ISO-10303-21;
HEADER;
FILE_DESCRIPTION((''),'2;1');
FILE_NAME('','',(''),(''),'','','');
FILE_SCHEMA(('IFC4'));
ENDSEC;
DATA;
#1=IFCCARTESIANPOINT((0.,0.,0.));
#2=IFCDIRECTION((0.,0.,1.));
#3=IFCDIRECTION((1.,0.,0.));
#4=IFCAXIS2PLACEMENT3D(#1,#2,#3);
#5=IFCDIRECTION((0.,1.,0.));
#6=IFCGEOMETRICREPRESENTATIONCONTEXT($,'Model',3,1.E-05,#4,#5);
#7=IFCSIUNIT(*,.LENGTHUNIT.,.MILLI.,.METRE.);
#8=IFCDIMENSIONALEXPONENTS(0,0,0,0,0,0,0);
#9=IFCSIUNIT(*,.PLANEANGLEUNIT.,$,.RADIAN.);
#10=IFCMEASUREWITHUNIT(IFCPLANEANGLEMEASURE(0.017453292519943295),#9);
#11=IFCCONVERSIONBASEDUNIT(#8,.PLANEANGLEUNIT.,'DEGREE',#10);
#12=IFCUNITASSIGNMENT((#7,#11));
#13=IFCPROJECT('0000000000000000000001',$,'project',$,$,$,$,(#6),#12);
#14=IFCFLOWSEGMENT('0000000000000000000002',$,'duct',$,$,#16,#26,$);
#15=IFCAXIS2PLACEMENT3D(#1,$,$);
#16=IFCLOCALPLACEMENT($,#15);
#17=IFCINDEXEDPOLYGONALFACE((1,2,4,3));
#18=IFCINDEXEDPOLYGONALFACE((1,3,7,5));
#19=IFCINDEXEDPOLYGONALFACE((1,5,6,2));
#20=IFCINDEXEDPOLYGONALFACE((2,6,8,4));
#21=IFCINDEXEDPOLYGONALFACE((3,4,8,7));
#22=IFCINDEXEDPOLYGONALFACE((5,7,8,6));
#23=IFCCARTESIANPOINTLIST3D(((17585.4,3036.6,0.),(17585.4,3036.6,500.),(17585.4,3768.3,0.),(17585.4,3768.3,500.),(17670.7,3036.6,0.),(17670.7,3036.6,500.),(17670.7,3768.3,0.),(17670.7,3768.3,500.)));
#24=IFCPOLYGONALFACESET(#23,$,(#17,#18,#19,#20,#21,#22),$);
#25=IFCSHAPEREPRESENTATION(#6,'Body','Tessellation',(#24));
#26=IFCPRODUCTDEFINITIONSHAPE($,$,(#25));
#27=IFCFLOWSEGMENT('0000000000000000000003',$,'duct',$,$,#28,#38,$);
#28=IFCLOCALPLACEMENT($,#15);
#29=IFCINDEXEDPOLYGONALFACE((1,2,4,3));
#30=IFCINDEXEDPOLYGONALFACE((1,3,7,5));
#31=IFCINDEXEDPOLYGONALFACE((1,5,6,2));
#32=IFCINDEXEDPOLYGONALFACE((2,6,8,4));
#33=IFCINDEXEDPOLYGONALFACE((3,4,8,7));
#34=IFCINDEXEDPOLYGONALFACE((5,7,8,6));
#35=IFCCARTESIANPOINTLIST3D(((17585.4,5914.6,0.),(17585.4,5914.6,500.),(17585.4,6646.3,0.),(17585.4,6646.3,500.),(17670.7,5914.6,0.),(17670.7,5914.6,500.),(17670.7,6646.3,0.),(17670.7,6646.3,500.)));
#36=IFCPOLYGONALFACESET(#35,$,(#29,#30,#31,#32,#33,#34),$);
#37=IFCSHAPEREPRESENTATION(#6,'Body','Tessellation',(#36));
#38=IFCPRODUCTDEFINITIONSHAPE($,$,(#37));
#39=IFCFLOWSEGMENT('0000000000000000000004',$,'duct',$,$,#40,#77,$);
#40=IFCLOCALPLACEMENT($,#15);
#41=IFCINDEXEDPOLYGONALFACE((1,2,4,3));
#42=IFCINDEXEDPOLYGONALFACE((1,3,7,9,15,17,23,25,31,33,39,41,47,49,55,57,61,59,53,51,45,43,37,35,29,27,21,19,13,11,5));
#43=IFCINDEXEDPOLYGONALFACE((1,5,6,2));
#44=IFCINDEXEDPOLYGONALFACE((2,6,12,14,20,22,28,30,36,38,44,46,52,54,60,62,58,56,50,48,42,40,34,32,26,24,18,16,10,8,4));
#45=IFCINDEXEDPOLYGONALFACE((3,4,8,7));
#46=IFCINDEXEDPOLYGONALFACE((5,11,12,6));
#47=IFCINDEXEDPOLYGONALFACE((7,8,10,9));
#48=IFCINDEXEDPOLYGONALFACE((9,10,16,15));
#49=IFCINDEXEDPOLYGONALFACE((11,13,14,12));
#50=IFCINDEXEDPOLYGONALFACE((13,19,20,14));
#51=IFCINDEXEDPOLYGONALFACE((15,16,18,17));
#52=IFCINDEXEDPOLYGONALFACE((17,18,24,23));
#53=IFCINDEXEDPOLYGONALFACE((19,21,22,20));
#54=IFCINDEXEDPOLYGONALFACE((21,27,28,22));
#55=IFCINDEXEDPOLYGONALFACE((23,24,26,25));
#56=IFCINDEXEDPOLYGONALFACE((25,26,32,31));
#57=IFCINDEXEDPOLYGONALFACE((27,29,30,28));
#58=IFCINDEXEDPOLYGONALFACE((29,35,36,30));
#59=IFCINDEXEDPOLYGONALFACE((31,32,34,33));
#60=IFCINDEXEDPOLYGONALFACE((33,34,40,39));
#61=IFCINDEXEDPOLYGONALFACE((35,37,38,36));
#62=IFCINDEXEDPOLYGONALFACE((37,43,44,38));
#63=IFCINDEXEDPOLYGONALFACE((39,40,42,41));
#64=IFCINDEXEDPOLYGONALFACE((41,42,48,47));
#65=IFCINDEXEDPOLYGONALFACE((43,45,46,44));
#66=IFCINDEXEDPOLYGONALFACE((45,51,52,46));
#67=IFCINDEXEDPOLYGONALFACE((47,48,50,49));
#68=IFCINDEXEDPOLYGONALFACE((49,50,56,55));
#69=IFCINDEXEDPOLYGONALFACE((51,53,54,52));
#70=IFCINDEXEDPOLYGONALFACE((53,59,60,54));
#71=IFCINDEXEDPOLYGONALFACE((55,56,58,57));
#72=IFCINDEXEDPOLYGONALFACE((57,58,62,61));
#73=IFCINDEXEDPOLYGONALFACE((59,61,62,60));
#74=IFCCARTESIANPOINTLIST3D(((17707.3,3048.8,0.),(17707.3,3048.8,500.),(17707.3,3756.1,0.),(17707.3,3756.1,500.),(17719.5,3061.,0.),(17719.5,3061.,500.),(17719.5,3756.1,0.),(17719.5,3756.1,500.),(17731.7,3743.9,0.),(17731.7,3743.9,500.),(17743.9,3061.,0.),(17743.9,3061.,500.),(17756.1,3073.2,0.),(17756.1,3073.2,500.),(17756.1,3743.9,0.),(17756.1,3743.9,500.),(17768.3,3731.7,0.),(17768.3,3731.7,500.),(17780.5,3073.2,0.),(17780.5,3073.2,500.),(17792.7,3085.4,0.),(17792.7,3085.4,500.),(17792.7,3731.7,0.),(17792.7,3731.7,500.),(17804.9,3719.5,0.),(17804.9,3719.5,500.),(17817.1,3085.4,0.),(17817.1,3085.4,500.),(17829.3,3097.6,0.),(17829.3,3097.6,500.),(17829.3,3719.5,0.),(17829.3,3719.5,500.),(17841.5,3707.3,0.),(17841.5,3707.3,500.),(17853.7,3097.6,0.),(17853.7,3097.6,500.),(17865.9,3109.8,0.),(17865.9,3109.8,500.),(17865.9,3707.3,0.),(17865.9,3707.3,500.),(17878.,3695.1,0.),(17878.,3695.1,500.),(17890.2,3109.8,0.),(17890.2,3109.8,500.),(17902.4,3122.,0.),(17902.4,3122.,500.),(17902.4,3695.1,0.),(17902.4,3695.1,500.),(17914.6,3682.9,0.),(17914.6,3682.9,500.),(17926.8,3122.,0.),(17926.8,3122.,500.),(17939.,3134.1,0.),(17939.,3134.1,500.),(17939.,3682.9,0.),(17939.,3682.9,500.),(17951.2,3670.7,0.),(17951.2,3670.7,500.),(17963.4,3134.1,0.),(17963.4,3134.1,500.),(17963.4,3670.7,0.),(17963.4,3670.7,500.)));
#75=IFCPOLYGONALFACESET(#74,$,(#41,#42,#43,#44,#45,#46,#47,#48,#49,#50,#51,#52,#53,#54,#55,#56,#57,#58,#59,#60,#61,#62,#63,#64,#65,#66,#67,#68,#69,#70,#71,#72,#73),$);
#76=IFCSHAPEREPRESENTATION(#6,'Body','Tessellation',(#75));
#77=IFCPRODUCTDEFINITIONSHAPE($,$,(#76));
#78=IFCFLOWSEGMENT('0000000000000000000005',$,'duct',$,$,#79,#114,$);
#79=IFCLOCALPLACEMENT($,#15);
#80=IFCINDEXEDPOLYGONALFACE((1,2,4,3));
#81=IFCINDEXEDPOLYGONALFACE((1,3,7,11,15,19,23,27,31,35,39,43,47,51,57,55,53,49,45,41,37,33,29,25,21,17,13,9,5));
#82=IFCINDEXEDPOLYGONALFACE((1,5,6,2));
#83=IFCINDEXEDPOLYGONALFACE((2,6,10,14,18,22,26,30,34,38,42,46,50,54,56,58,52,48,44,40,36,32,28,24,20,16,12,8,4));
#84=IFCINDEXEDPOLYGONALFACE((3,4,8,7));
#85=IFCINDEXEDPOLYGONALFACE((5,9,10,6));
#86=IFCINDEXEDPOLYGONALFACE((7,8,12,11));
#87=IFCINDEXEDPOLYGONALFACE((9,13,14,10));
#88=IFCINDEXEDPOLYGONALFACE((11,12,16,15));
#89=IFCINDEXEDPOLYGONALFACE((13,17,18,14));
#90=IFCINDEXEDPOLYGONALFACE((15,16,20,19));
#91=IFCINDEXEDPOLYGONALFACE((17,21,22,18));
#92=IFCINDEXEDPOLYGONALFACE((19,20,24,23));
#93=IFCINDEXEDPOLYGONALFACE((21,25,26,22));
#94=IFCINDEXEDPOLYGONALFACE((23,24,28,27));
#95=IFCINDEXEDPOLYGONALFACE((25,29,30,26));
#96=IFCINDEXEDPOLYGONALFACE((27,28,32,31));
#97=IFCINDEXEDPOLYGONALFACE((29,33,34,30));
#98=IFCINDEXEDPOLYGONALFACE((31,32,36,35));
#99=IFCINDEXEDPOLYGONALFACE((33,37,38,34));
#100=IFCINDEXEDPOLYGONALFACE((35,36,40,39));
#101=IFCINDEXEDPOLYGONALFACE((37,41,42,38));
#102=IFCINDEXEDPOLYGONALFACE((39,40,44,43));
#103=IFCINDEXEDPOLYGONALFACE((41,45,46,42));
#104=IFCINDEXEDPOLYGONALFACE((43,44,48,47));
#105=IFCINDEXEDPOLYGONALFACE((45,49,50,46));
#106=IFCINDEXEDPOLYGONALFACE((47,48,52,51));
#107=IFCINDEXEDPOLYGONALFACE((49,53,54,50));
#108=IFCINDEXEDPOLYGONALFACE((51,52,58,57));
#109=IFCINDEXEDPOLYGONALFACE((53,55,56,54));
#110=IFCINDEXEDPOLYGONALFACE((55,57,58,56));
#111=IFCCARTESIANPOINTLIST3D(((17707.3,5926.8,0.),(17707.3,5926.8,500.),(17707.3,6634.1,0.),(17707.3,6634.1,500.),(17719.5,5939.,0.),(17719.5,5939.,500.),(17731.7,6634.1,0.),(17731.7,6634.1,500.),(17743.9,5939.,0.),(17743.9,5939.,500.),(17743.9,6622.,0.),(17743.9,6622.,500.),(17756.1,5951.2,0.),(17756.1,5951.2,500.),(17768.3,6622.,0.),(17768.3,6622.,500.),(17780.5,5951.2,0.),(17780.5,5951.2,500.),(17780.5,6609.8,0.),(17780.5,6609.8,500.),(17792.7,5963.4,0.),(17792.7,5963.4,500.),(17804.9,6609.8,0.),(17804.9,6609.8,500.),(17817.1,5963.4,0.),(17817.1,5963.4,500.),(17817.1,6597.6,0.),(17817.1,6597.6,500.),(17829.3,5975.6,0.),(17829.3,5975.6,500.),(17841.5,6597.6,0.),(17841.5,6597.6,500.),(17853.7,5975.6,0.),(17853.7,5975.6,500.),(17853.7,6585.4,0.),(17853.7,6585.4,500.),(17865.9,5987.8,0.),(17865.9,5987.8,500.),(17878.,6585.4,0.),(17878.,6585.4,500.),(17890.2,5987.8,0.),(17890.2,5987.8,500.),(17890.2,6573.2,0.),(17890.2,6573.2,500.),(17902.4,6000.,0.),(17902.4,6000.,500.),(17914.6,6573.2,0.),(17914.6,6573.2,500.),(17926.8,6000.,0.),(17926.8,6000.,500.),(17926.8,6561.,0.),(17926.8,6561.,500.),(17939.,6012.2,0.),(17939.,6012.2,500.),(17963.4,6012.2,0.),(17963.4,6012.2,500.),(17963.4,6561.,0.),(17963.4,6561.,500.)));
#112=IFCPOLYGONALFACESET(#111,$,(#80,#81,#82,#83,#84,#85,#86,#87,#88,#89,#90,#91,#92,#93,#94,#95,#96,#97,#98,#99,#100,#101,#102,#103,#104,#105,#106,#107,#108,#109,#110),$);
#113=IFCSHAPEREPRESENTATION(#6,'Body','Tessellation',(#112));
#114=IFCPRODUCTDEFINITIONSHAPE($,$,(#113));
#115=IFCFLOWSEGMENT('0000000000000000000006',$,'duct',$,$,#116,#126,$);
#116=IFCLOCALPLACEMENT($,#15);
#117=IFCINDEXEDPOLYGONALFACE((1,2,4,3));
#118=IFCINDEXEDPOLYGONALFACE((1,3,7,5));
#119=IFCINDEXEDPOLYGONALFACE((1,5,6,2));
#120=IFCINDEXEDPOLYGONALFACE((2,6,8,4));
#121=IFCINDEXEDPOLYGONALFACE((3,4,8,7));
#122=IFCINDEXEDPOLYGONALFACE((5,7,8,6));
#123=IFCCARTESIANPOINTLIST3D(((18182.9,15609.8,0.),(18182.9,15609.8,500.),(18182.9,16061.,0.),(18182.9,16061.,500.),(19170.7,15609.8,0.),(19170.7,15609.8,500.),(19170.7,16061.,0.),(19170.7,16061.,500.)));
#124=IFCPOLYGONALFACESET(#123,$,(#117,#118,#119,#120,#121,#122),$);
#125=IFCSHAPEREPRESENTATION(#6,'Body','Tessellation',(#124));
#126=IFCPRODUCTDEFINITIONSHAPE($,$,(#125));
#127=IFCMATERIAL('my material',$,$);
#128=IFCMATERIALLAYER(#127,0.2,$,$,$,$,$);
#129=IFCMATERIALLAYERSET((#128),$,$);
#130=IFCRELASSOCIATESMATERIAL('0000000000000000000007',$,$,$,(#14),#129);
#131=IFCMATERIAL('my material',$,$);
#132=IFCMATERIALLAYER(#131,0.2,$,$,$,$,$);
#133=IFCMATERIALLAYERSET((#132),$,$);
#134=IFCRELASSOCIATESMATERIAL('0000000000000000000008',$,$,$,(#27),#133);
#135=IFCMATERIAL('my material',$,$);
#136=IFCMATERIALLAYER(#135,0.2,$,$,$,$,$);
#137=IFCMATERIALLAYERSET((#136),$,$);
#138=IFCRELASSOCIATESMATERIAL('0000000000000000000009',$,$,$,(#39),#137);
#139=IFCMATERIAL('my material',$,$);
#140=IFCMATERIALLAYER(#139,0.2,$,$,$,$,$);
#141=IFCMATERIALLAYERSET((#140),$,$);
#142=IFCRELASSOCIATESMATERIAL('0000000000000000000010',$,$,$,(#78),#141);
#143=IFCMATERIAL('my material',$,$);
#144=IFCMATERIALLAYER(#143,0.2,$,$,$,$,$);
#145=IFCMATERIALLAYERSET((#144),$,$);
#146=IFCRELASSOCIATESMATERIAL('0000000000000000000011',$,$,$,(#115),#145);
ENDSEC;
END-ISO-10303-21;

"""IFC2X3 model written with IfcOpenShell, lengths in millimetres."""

from ifc_helpers import new_model, entity, si_unit, converted_unit, direction, origin_with_axes, place, context, project, polyline, outline, extrude, material, layer, layer_set, layer_usage, element, save


model = new_model("IFC2X3")

# Units and contexts
model_context = context("Model", 3, precision=1e-05, world=origin_with_axes(), true_north=direction((0.0, 1.0, 0.0)))
ifc_project = project(units=[si_unit("LENGTHUNIT", "METRE", prefix="MILLI"), converted_unit("PLANEANGLEUNIT", "DEGREE", entity("IfcPlaneAngleMeasure", 0.017453292519943295), si_unit("PLANEANGLEUNIT", "RADIAN"), dimensions=[0, 0, 0, 0, 0, 0, 0])], contexts=[model_context])

# Flow segments
ifc_material_1 = material(Name="my material")
ifc_layer_1 = layer(ifc_material_1, 0.2)
ifc_layer_set_1 = layer_set([ifc_layer_1])
ifc_layer_usage_1 = layer_usage(ifc_layer_set_1, "AXIS2", "POSITIVE", -0.1)
flow_segment_1_placement = place(None, origin_with_axes())
element("IfcFlowSegment", 1, at=flow_segment_1_placement, material=ifc_layer_usage_1, Name="duct", context=model_context, shape_type="SweptSolid", body=[
    extrude(outline(polyline([(17585.4, 3036.6), (17670.7, 3036.6), (17670.7, 3768.3), (17585.4, 3768.3), (17585.4, 3036.6)])), origin_with_axes(), (0.0, 0.0, 1.0), 500.0),
])
ifc_material_2 = material(Name="my material")
ifc_layer_2 = layer(ifc_material_2, 0.2)
ifc_layer_set_2 = layer_set([ifc_layer_2])
ifc_layer_usage_2 = layer_usage(ifc_layer_set_2, "AXIS2", "POSITIVE", -0.1)
flow_segment_2_placement = place(None, origin_with_axes())
element("IfcFlowSegment", 2, at=flow_segment_2_placement, material=ifc_layer_usage_2, Name="duct", context=model_context, shape_type="SweptSolid", body=[
    extrude(outline(polyline([(17585.4, 5914.6), (17670.7, 5914.6), (17670.7, 6646.3), (17585.4, 6646.3), (17585.4, 5914.6)])), origin_with_axes(), (0.0, 0.0, 1.0), 500.0),
])
ifc_material_3 = material(Name="my material")
ifc_layer_3 = layer(ifc_material_3, 0.2)
ifc_layer_set_3 = layer_set([ifc_layer_3])
ifc_layer_usage_3 = layer_usage(ifc_layer_set_3, "AXIS2", "POSITIVE", -0.1)
flow_segment_3_placement = place(None, origin_with_axes())
element("IfcFlowSegment", 3, at=flow_segment_3_placement, material=ifc_layer_usage_3, Name="duct", context=model_context, shape_type="SweptSolid", body=[
    extrude(outline(polyline([(17707.3, 3048.8), (17719.5, 3061.0), (17743.9, 3061.0), (17756.1, 3073.2), (17780.5, 3073.2), (17792.7, 3085.4), (17817.1, 3085.4), (17829.3, 3097.6), (17853.7, 3097.6), (17865.9, 3109.8), (17890.2, 3109.8), (17902.4, 3122.0), (17926.8, 3122.0), (17939.0, 3134.1), (17963.4, 3134.1), (17963.4, 3670.7), (17951.2, 3670.7), (17939.0, 3682.9), (17914.6, 3682.9), (17902.4, 3695.1), (17878.0, 3695.1), (17865.9, 3707.3), (17841.5, 3707.3), (17829.3, 3719.5), (17804.9, 3719.5), (17792.7, 3731.7), (17768.3, 3731.7), (17756.1, 3743.9), (17731.7, 3743.9), (17719.5, 3756.1), (17707.3, 3756.1), (17707.3, 3048.8)])), origin_with_axes(), (0.0, 0.0, 1.0), 500.0),
])
ifc_material_4 = material(Name="my material")
ifc_layer_4 = layer(ifc_material_4, 0.2)
ifc_layer_set_4 = layer_set([ifc_layer_4])
ifc_layer_usage_4 = layer_usage(ifc_layer_set_4, "AXIS2", "POSITIVE", -0.1)
flow_segment_4_placement = place(None, origin_with_axes())
element("IfcFlowSegment", 4, at=flow_segment_4_placement, material=ifc_layer_usage_4, Name="duct", context=model_context, shape_type="SweptSolid", body=[
    extrude(outline(polyline([(17707.3, 5926.8), (17719.5, 5939.0), (17743.9, 5939.0), (17756.1, 5951.2), (17780.5, 5951.2), (17792.7, 5963.4), (17817.1, 5963.4), (17829.3, 5975.6), (17853.7, 5975.6), (17865.9, 5987.8), (17890.2, 5987.8), (17902.4, 6000.0), (17926.8, 6000.0), (17939.0, 6012.2), (17963.4, 6012.2), (17963.4, 6561.0), (17926.8, 6561.0), (17914.6, 6573.2), (17890.2, 6573.2), (17878.0, 6585.4), (17853.7, 6585.4), (17841.5, 6597.6), (17817.1, 6597.6), (17804.9, 6609.8), (17780.5, 6609.8), (17768.3, 6622.0), (17743.9, 6622.0), (17731.7, 6634.1), (17707.3, 6634.1), (17707.3, 5926.8)])), origin_with_axes(), (0.0, 0.0, 1.0), 500.0),
])
ifc_material_5 = material(Name="my material")
ifc_layer_5 = layer(ifc_material_5, 0.2)
ifc_layer_set_5 = layer_set([ifc_layer_5])
ifc_layer_usage_5 = layer_usage(ifc_layer_set_5, "AXIS2", "POSITIVE", -0.1)
flow_segment_5_placement = place(None, origin_with_axes())
element("IfcFlowSegment", 5, at=flow_segment_5_placement, material=ifc_layer_usage_5, Name="duct", context=model_context, shape_type="SweptSolid", body=[
    extrude(outline(polyline([(18182.9, 15609.8), (19170.7, 15609.8), (19170.7, 16061.0), (18182.9, 16061.0), (18182.9, 15609.8)])), origin_with_axes(), (0.0, 0.0, 1.0), 500.0),
])

save(model, "model.ifc")
